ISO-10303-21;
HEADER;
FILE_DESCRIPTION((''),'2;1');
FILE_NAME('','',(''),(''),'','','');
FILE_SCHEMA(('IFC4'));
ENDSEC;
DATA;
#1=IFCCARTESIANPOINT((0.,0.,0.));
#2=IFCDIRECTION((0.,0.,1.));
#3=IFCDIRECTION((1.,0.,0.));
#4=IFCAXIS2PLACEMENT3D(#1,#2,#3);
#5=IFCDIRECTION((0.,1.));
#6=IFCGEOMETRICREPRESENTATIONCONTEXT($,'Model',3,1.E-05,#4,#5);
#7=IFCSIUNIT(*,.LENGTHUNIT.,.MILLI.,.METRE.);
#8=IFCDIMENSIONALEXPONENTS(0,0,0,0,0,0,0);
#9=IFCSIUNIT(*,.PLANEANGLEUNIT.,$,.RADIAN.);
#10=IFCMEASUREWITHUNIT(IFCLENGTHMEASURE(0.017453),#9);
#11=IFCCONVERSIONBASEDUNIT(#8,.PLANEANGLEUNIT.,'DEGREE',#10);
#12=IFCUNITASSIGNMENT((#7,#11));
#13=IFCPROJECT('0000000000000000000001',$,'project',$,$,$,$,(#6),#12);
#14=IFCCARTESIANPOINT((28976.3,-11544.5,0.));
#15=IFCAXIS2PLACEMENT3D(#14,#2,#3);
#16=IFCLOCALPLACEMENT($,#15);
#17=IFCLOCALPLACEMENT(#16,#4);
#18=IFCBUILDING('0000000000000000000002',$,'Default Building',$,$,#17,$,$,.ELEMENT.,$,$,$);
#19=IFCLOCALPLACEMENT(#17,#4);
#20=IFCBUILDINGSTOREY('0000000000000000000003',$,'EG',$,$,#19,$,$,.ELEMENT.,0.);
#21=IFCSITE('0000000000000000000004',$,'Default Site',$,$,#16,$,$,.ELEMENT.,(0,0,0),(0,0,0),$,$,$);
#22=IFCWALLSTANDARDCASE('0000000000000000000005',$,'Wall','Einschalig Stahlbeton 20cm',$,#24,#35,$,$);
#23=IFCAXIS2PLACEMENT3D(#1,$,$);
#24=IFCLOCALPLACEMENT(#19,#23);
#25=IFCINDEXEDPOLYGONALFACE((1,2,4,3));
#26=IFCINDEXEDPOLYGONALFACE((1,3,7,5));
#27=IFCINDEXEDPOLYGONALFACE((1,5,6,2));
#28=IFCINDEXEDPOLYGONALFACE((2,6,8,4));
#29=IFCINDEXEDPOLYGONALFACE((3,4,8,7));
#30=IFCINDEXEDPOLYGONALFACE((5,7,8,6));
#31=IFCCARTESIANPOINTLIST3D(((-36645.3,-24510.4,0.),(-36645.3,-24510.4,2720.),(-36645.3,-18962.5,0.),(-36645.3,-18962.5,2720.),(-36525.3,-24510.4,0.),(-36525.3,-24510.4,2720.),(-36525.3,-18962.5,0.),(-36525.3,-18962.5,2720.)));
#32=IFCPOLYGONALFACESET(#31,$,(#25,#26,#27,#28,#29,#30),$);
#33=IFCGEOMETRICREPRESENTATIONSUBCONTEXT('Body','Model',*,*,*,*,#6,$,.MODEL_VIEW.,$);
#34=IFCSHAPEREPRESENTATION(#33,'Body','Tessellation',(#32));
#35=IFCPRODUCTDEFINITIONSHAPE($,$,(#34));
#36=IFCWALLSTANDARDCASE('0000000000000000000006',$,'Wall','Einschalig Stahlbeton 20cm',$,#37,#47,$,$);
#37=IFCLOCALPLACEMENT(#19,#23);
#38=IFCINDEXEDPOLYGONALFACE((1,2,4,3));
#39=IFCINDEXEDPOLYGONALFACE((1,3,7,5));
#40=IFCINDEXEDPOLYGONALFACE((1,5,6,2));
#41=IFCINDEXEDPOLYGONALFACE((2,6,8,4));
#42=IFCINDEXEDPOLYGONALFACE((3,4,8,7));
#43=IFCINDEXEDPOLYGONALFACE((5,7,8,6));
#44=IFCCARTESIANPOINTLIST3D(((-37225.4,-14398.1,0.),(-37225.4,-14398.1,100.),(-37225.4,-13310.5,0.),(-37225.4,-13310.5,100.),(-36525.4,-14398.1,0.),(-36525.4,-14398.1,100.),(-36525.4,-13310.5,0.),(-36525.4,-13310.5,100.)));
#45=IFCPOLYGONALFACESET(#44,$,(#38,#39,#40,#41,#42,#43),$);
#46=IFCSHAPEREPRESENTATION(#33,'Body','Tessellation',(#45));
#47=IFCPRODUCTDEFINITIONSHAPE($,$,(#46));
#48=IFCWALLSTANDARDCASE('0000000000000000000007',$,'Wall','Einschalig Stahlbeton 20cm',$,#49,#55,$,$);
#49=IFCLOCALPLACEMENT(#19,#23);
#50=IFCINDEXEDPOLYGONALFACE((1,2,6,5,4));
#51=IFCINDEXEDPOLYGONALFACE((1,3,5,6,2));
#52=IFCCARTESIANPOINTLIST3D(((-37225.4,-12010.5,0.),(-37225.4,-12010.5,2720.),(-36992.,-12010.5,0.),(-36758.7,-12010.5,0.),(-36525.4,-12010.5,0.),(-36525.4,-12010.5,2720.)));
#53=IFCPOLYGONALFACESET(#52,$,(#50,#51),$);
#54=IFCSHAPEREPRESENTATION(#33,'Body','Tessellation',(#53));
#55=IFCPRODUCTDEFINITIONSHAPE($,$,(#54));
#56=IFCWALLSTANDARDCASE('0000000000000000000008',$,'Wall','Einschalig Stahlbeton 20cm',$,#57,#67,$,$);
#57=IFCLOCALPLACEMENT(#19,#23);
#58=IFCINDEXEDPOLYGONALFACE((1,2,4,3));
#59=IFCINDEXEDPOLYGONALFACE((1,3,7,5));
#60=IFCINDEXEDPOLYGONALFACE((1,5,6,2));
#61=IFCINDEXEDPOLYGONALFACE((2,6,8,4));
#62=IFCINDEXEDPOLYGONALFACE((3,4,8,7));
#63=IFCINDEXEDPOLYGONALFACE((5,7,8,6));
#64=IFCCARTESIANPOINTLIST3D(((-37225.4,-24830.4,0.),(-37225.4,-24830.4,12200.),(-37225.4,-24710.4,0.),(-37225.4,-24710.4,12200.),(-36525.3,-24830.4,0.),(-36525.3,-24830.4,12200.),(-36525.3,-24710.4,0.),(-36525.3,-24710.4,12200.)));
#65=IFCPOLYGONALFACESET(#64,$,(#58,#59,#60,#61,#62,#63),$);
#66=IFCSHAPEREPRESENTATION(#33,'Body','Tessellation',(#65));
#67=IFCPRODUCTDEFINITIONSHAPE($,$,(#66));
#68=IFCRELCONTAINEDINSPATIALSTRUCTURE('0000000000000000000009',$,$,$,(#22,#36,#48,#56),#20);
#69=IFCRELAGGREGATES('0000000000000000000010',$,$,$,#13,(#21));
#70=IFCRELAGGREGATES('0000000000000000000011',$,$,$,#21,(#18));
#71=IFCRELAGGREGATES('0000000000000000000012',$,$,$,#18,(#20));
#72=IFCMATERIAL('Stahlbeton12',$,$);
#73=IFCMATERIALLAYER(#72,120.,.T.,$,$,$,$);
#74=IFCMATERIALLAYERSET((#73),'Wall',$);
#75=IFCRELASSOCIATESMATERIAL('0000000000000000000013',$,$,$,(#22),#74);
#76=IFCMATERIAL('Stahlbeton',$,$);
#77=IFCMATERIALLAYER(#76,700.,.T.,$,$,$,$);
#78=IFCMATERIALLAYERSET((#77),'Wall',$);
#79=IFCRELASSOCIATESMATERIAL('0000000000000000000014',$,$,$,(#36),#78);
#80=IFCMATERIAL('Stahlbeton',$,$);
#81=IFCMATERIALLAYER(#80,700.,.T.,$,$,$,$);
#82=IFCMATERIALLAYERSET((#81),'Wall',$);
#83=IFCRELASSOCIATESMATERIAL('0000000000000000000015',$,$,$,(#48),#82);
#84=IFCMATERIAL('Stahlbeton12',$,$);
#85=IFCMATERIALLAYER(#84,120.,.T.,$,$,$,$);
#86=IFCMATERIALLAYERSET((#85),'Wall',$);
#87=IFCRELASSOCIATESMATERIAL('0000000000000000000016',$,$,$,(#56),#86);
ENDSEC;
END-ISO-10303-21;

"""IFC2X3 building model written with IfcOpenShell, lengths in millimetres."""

from ifc_helpers import new_model, entity, si_unit, converted_unit, direction, frame, origin_with_axes, place, context, subcontext, project, spatial, polyline, outline, extrude, material, layer, layer_set, layer_usage, element, save


model = new_model("IFC2X3")

# Units and contexts
model_context = context("Model", 3, precision=1e-05, world=origin_with_axes(), true_north=direction((0.0, 1.0)))
body_context = subcontext(model_context, "Body", "Model", "MODEL_VIEW")
ifc_project = project(units=[si_unit("LENGTHUNIT", "METRE", prefix="MILLI"), converted_unit("PLANEANGLEUNIT", "DEGREE", entity("IfcLengthMeasure", 0.017453), si_unit("PLANEANGLEUNIT", "RADIAN"), dimensions=[0, 0, 0, 0, 0, 0, 0])], contexts=[model_context])

# Site, building, storey
site_placement = place(None, frame((28976.3, -11544.5, 0.0), z_axis=(0.0, 0.0, 1.0), x_axis=(1.0, 0.0, 0.0)))
site = spatial("IfcSite", under=ifc_project, at=site_placement, Name="Default Site", CompositionType="ELEMENT", RefLatitude=(0, 0, 0), RefLongitude=(0, 0, 0))
building_placement = place(site_placement, origin_with_axes())
building = spatial("IfcBuilding", under=site, at=building_placement, Name="Default Building", CompositionType="ELEMENT")
storey_placement = place(building_placement, origin_with_axes())
storey = spatial("IfcBuildingStorey", under=building, at=storey_placement, Name="EG", CompositionType="ELEMENT", Elevation=0.0)

# Walls
ifc_material_1 = material(Name="Stahlbeton12")
ifc_layer_1 = layer(ifc_material_1, 120.0, ventilated=True)
ifc_layer_set_1 = layer_set([ifc_layer_1], Name="Wall")
ifc_layer_usage_1 = layer_usage(ifc_layer_set_1, "AXIS2", "POSITIVE", -60.0)
wall_1_placement = place(storey_placement, frame((-36585.3, -24510.4, 0.0), z_axis=(0.0, 0.0, 1.0), x_axis=(0.0, 1.0, 0.0)))
element("IfcWallStandardCase", 1, at=wall_1_placement, inside=storey, material=ifc_layer_usage_1, Name="Wall", Description="Einschalig Stahlbeton 20cm", context=body_context, shape_type="SweptSolid", body=[
    extrude(outline(polyline([(0.0, -60.0), (0.0, 60.0), (5548.0, 60.0), (5548.0, -60.0), (0.0, -60.0)])), origin_with_axes(), (0.0, 0.0, 1.0), 2720.0),
])
ifc_material_2 = material(Name="Stahlbeton")
ifc_layer_2 = layer(ifc_material_2, 700.0, ventilated=True)
ifc_layer_set_2 = layer_set([ifc_layer_2], Name="Wall")
ifc_layer_usage_2 = layer_usage(ifc_layer_set_2, "AXIS2", "POSITIVE", -350.0)
wall_2_placement = place(storey_placement, frame((-36875.4, -13310.5, 0.0), z_axis=(0.0, 0.0, 1.0), x_axis=(0.0, -1.0, 0.0)))
element("IfcWallStandardCase", 2, at=wall_2_placement, inside=storey, material=ifc_layer_usage_2, Name="Wall", Description="Einschalig Stahlbeton 20cm", context=body_context, shape_type="SweptSolid", body=[
    extrude(outline(polyline([(0.0, -350.0), (0.0, 350.0), (1087.7, 350.0), (1087.7, -350.0), (0.0, -350.0)])), origin_with_axes(), (0.0, 0.0, 1.0), 100.0),
])
ifc_material_3 = material(Name="Stahlbeton")
ifc_layer_3 = layer(ifc_material_3, 700.0, ventilated=True)
ifc_layer_set_3 = layer_set([ifc_layer_3], Name="Wall")
ifc_layer_usage_3 = layer_usage(ifc_layer_set_3, "AXIS2", "POSITIVE", -350.0)
wall_3_placement = place(storey_placement, frame((-36875.4, -12010.5, 0.0), z_axis=(0.0, 0.0, 1.0), x_axis=(0.0, 1.0, 0.0)))
element("IfcWallStandardCase", 3, at=wall_3_placement, inside=storey, material=ifc_layer_usage_3, Name="Wall", Description="Einschalig Stahlbeton 20cm", context=body_context, shape_type="SweptSolid", body=[
    extrude(outline(polyline([(0.0, -350.0), (0.0, 350.0), (0.0, 350.0), (0.0, -350.0), (0.0, -350.0)])), origin_with_axes(), (0.0, 0.0, 1.0), 2720.0),
])
ifc_material_4 = material(Name="Stahlbeton12")
ifc_layer_4 = layer(ifc_material_4, 120.0, ventilated=True)
ifc_layer_set_4 = layer_set([ifc_layer_4], Name="Wall")
ifc_layer_usage_4 = layer_usage(ifc_layer_set_4, "AXIS2", "POSITIVE", -60.0)
wall_4_placement = place(storey_placement, frame((-37225.4, -24770.4, 0.0), z_axis=(0.0, 0.0, 1.0), x_axis=(1.0, -0.000029, 0.0)))
element("IfcWallStandardCase", 4, at=wall_4_placement, inside=storey, material=ifc_layer_usage_4, Name="Wall", Description="Einschalig Stahlbeton 20cm", context=body_context, shape_type="SweptSolid", body=[
    extrude(outline(polyline([(0.0, -60.0), (0.0, 60.0), (700.0, 60.0), (700.0, -60.0), (0.0, -60.0)])), origin_with_axes(), (0.0, 0.0, 1.0), 12200.0),
])

save(model, "model.ifc")
